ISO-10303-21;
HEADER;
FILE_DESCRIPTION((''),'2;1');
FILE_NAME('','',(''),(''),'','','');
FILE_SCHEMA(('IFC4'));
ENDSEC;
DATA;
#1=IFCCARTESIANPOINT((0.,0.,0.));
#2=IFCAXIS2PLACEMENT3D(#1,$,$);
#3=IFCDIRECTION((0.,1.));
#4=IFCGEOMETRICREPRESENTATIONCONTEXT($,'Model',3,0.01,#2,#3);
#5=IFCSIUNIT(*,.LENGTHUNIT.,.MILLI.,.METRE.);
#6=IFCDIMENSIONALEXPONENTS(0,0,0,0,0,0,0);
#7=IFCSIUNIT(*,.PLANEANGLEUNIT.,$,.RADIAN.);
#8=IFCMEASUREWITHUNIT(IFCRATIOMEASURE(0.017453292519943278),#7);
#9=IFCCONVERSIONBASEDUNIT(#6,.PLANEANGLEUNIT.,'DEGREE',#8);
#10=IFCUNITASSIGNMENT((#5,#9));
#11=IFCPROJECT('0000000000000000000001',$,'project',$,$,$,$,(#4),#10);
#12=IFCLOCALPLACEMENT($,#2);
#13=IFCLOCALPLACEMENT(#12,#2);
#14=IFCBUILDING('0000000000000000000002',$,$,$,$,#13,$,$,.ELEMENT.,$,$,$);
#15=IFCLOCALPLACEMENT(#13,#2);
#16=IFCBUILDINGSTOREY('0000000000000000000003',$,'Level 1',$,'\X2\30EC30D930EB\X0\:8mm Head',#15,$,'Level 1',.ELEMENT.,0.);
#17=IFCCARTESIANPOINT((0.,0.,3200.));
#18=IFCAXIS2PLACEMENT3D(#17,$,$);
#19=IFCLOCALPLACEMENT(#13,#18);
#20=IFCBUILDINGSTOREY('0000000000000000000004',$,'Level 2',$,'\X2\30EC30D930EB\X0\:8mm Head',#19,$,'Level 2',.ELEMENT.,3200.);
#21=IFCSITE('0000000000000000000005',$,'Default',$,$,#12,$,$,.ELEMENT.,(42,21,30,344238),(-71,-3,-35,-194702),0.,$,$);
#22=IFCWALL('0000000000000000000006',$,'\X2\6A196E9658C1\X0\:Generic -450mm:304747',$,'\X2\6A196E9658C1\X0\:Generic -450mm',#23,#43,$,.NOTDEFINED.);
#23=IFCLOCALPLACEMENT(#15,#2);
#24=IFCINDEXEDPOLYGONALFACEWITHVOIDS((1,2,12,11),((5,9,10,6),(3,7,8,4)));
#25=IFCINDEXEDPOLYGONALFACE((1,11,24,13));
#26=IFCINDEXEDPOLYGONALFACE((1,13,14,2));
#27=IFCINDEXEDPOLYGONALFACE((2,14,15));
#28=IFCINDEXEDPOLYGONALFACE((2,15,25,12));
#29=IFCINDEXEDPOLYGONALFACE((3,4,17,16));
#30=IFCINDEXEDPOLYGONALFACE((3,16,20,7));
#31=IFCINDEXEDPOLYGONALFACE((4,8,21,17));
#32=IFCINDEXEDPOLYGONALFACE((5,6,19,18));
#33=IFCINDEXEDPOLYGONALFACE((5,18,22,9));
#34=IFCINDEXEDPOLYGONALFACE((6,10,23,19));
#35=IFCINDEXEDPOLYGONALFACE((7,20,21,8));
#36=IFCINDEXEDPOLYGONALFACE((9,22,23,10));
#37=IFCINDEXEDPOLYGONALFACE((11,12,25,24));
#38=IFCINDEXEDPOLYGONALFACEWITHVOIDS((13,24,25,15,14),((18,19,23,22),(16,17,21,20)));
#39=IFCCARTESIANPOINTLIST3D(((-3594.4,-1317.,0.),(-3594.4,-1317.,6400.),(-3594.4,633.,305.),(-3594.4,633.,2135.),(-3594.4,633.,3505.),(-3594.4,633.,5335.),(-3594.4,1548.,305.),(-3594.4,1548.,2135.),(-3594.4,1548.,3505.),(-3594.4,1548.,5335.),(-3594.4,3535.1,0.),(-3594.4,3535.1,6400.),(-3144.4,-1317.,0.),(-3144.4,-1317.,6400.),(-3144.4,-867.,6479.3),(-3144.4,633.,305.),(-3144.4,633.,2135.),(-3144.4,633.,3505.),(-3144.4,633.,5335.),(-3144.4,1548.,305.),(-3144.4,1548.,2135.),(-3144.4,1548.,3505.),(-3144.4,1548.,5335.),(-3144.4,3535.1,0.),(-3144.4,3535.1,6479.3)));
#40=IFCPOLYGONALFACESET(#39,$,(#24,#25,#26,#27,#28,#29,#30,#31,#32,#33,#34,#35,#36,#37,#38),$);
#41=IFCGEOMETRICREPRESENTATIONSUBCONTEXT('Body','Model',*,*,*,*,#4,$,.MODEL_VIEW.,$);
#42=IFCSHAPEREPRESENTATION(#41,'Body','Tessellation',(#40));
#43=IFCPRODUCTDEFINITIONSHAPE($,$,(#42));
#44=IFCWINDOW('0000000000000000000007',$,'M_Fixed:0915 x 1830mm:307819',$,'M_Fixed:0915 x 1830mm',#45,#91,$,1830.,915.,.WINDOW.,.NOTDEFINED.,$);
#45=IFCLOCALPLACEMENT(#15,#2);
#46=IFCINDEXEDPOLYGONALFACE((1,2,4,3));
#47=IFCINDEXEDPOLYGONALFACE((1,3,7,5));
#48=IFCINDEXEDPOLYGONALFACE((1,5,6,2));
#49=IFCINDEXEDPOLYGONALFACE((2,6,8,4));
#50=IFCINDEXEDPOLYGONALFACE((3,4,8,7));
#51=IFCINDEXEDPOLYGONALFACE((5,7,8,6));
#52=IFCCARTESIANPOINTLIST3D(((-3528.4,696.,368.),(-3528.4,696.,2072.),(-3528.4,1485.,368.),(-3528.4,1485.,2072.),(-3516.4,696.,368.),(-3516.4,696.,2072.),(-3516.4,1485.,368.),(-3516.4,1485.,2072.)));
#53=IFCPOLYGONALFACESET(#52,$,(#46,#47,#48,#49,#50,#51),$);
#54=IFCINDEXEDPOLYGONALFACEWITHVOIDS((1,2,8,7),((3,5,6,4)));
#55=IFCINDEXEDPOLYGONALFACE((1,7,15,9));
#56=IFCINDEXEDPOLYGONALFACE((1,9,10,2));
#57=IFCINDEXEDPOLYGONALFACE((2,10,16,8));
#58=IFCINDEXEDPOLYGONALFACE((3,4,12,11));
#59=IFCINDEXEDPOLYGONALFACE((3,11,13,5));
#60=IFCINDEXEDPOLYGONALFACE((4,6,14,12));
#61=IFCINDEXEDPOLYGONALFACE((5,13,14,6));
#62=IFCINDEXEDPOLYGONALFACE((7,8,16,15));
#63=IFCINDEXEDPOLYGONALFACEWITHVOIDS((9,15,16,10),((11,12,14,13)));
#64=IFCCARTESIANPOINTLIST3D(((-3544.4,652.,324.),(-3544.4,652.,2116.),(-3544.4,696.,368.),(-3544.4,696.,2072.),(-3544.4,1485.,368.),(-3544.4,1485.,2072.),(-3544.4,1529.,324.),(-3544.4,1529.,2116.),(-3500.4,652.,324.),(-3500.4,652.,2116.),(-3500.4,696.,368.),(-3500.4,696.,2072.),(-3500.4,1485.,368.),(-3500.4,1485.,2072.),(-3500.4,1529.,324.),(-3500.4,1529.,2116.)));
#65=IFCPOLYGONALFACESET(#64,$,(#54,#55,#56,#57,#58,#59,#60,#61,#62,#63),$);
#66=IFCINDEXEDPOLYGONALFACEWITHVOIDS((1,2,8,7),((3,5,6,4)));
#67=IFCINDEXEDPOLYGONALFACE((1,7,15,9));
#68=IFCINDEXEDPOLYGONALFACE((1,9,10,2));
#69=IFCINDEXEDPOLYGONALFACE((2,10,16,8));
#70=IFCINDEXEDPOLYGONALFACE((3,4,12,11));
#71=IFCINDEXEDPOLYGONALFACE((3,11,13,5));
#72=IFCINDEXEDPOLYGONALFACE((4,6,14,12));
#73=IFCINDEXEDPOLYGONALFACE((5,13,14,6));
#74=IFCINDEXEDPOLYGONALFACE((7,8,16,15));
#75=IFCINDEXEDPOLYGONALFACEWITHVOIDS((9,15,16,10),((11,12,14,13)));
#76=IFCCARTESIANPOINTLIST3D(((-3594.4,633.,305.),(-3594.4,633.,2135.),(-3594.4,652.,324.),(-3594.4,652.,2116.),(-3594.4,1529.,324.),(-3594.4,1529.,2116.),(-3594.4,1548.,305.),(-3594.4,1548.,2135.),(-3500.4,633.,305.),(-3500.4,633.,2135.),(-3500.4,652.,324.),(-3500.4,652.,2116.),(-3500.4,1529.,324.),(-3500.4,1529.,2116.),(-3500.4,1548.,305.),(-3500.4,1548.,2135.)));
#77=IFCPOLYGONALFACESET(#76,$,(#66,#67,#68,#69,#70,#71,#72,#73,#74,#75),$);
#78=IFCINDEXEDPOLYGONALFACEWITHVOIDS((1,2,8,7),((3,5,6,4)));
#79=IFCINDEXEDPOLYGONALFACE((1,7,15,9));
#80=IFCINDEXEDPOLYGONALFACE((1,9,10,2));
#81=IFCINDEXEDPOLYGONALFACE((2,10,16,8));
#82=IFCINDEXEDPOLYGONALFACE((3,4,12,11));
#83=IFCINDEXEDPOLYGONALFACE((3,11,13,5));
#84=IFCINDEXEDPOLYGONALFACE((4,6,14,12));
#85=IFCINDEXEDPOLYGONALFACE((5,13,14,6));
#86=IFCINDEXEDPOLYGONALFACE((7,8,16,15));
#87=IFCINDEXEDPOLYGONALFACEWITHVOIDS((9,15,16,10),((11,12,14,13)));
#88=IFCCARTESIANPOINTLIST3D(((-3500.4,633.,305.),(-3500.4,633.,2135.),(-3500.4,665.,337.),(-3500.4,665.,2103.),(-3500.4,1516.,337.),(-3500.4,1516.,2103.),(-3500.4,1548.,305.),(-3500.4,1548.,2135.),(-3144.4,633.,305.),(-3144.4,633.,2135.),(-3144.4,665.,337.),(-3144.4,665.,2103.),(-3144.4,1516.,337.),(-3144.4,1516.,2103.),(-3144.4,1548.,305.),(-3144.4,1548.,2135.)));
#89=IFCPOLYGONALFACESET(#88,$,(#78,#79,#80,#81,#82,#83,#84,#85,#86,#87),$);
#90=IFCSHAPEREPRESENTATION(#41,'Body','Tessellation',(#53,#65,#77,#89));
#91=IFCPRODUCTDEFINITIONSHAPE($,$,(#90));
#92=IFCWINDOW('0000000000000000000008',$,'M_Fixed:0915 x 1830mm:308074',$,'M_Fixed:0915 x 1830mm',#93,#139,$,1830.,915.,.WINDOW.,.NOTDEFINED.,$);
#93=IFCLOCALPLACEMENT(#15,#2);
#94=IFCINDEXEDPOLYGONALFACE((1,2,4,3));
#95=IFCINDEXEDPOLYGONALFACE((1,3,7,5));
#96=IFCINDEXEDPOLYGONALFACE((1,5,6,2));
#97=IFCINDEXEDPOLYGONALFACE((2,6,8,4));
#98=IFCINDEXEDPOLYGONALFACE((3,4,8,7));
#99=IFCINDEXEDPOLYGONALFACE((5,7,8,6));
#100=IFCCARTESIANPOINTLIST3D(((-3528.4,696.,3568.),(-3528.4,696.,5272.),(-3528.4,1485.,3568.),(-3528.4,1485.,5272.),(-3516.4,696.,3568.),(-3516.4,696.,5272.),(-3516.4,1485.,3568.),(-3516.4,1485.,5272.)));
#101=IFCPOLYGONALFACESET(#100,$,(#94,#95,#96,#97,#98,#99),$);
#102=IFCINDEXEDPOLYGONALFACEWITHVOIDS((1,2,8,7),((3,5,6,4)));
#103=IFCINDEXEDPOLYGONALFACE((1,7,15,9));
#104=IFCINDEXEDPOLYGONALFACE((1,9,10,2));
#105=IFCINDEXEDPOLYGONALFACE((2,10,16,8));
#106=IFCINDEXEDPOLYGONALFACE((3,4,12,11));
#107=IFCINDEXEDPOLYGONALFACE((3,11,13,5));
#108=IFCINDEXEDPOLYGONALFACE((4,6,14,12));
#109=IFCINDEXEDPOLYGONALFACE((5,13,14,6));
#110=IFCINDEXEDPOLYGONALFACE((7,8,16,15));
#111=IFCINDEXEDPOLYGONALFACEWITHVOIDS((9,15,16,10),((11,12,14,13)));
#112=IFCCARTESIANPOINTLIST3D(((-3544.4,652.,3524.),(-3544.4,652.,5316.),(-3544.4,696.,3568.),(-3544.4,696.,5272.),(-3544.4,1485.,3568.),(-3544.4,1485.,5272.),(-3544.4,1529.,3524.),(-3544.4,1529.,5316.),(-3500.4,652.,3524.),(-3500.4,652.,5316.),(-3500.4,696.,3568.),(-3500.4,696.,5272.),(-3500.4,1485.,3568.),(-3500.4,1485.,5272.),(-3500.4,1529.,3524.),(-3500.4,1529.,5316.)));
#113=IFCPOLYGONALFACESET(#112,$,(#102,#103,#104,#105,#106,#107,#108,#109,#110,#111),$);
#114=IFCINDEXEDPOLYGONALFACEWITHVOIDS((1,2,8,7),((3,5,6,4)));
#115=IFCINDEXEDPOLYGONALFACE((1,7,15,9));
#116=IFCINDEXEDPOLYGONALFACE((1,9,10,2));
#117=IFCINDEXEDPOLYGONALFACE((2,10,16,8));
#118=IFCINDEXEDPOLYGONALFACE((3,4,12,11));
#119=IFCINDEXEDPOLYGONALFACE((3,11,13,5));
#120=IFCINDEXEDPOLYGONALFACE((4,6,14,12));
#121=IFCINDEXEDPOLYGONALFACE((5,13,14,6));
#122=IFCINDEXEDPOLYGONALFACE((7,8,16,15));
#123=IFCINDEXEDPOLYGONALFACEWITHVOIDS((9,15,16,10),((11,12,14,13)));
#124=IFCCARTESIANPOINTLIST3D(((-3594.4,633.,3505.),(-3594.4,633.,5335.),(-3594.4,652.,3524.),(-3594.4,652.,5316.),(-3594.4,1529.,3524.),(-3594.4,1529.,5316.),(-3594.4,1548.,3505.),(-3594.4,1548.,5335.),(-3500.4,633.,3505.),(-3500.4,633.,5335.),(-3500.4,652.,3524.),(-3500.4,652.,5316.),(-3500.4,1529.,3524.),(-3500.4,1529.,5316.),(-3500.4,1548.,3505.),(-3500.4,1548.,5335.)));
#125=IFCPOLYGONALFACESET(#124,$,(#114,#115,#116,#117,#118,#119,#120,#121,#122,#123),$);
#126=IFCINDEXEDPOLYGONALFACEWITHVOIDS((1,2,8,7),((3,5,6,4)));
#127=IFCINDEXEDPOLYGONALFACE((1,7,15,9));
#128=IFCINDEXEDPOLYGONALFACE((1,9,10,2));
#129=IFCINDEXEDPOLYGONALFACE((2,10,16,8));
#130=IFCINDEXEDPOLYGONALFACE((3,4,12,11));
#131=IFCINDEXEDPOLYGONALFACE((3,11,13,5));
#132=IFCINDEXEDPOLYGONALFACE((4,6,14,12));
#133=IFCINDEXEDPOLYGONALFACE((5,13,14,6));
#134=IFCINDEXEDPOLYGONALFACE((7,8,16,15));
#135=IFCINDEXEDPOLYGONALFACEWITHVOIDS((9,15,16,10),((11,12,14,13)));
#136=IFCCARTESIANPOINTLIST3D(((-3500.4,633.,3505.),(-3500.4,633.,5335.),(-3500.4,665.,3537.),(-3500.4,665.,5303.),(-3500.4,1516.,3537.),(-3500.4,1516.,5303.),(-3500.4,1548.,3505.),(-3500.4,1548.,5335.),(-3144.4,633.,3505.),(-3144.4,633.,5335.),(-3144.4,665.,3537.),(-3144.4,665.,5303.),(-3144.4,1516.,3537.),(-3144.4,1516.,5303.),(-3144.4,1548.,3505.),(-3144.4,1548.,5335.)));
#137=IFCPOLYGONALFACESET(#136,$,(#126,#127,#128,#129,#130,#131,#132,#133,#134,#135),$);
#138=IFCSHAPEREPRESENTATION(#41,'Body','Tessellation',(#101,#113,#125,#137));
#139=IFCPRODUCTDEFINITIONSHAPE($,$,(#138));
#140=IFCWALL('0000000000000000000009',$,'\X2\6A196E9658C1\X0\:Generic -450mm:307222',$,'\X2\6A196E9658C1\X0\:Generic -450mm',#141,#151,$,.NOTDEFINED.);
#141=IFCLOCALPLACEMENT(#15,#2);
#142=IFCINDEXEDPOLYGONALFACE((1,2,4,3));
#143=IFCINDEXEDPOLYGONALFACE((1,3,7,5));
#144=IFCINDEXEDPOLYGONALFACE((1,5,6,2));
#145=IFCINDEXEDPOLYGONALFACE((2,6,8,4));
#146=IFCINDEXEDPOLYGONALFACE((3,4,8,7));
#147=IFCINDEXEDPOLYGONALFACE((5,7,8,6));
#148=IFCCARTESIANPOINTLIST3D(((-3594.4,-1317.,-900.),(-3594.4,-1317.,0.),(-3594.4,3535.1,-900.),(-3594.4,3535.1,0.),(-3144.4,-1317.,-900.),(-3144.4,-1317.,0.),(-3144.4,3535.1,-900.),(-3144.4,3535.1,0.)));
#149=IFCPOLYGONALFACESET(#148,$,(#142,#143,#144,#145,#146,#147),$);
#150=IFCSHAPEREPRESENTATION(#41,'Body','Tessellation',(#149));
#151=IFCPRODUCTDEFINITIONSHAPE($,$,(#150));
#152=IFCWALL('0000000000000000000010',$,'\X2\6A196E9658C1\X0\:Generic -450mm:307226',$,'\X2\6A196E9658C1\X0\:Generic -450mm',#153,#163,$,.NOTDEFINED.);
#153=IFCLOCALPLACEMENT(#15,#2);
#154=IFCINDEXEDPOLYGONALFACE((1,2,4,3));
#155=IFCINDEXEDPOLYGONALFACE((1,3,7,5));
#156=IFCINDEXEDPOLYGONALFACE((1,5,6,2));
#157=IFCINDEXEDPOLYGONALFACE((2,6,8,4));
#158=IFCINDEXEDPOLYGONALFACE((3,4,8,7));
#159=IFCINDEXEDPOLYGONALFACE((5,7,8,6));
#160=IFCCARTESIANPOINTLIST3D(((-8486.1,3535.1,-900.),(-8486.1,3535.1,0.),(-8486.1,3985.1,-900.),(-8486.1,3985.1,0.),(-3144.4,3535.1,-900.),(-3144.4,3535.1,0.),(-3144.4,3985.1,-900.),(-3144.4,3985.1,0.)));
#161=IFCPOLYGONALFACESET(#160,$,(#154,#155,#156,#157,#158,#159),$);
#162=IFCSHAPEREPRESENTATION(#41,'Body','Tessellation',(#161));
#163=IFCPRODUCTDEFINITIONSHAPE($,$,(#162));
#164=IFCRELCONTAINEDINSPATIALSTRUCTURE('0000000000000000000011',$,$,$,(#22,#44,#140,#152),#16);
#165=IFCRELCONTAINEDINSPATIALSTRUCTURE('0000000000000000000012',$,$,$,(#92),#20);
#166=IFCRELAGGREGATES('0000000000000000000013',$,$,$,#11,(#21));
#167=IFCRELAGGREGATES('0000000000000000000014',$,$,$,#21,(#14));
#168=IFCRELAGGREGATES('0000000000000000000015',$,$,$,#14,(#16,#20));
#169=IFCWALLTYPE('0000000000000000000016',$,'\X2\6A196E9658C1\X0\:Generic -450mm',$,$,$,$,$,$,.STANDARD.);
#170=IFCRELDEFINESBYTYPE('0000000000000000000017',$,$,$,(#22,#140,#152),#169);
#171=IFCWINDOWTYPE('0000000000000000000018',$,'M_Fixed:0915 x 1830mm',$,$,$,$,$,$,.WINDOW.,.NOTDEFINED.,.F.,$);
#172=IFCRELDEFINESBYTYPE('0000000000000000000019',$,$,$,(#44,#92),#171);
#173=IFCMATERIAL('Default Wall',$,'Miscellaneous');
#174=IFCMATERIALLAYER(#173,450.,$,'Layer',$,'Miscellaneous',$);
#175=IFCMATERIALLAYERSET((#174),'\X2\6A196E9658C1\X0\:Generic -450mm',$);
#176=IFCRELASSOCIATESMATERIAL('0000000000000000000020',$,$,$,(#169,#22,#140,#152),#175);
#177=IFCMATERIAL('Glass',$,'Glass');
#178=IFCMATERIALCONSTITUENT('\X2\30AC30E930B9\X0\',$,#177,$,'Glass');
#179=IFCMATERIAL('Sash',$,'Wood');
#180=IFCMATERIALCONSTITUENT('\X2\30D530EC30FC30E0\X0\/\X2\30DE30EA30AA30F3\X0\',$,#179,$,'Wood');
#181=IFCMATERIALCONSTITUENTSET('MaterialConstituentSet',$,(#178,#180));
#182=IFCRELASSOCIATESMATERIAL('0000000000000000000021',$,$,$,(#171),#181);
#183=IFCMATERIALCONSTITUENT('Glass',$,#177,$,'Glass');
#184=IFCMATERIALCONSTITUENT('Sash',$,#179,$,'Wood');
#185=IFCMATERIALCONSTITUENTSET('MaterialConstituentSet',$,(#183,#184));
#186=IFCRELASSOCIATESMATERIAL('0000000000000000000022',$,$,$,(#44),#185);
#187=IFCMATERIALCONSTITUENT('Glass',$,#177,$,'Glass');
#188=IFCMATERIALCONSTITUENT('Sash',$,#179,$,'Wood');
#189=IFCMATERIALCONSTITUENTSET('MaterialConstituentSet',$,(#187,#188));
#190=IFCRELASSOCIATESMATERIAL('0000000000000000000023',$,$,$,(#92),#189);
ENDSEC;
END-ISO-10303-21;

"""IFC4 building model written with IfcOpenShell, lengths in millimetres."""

from ifc_helpers import new_model, entity, si_unit, converted_unit, direction, frame, frame_2d, origin, origin_2d_with_axis, place, context, subcontext, project, spatial, polyline, rectangle, outline, extrude, clip, bounded_halfspace, source, transform, mapped, material, layer, layer_set, layer_usage, constituent, constituent_set, type_object, type_shapes, element, fill, save


model = new_model("IFC4")

# Units and contexts
model_context = context("Model", 3, precision=0.01, world=origin(), true_north=direction((0.0, 1.0)))
body_context = subcontext(model_context, "Body", "Model", "MODEL_VIEW")
ifc_project = project(units=[si_unit("LENGTHUNIT", "METRE", prefix="MILLI"), converted_unit("PLANEANGLEUNIT", "DEGREE", entity("IfcRatioMeasure", 0.017453292519943278), si_unit("PLANEANGLEUNIT", "RADIAN"), dimensions=[0, 0, 0, 0, 0, 0, 0])], contexts=[model_context])

# Site, building, storey
site_placement = place(None, origin())
site = spatial("IfcSite", under=ifc_project, at=site_placement, Name="Default", CompositionType="ELEMENT", RefLatitude=(42, 21, 30, 344238), RefLongitude=(-71, -3, -35, -194702), RefElevation=0.0)
building_placement = place(site_placement, origin())
building = spatial("IfcBuilding", under=site, at=building_placement, CompositionType="ELEMENT")
storey_1_placement = place(building_placement, origin())
storey_1 = spatial("IfcBuildingStorey", under=building, at=storey_1_placement, Name="Level 1", ObjectType="レベル:8mm Head", LongName="Level 1", CompositionType="ELEMENT", Elevation=0.0)

# Wall, openings, window
ifc_material_1 = material(Name="Default Wall", Category="Miscellaneous")
ifc_layer_1 = layer(ifc_material_1, 450.0, Name="Layer", Category="Miscellaneous")
ifc_layer_set_1 = layer_set([ifc_layer_1], Name="標準壁:Generic -450mm")
ifc_layer_usage_1 = layer_usage(ifc_layer_set_1, "AXIS2", "NEGATIVE", 225.0)
wall_type_1 = type_object("IfcWallType", Name="標準壁:Generic -450mm", PredefinedType="STANDARD", material=ifc_layer_set_1)
wall_1_placement = place(storey_1_placement, frame((-3369.4, -1317.0, 0.0), z_axis=(0.0, 0.0, 1.0), x_axis=(0.0, 1.0, 0.0)))
wall_1 = element("IfcWall", 1, at=wall_1_placement, inside=storey_1, type_object=wall_type_1, material=ifc_layer_usage_1, Name="標準壁:Generic -450mm:304747", ObjectType="標準壁:Generic -450mm", PredefinedType="NOTDEFINED", context=body_context, shape_type="Clipping", body=[
    clip(clip(extrude(rectangle(XDim=4852.1, YDim=450.0, at=frame_2d((2426.0, 0.0), x_axis=(-1.0, 0.0))), origin(), (0.0, 0.0, 1.0), 6479.3), bounded_halfspace(frame((0.0, -225.0, 6400.0), z_axis=(-0.173648, 0.0, 0.984808), x_axis=(0.0, -1.0, 0.0)), False, frame((0.0, -225.0, 6400.0)), polyline([(0.0, 0.0), (450.0, 0.0), (0.0, 450.0), (0.0, 0.0)]))), bounded_halfspace(frame((450.0, -225.0, 6479.3), z_axis=(0.0, 0.173648, 0.984808), x_axis=(-1.0, 0.0, 0.0)), False, frame((450.0, -225.0, 6479.3)), polyline([(0.0, 0.0), (4402.1, 0.0), (4402.1, 450.0), (-450.0, 450.0), (0.0, 0.0)]))),
])
opening_1_placement = place(wall_1_placement, frame((1950.0, -225.0, 305.0)))
opening_1 = element("IfcOpeningElement", 2, at=opening_1_placement, cuts=wall_1, PredefinedType="OPENING", context=body_context, shape_type="SweptSolid", body=[
    extrude(rectangle(XDim=1830.0, YDim=915.0, at=frame_2d((915.0, 457.5), x_axis=(1.0, 0.0))), frame((0.0, 0.0, 0.0), z_axis=(0.0, 1.0, 0.0), x_axis=(0.0, 0.0, 1.0)), (0.0, 0.0, 1.0), 450.0),
])
opening_2_placement = place(wall_1_placement, frame((1950.0, -225.0, 3505.0)))
opening_2 = element("IfcOpeningElement", 3, at=opening_2_placement, cuts=wall_1, PredefinedType="OPENING", context=body_context, shape_type="SweptSolid", body=[
    extrude(rectangle(XDim=1830.0, YDim=915.0, at=frame_2d((915.0, 457.5), x_axis=(1.0, 0.0))), frame((0.0, 0.0, 0.0), z_axis=(0.0, 1.0, 0.0), x_axis=(0.0, 0.0, 1.0)), (0.0, 0.0, 1.0), 450.0),
])
ifc_material_2 = material(Name="Glass", Category="Glass")
ifc_constituent_1 = constituent(ifc_material_2, Name="Glass", Category="Glass")
ifc_material_3 = material(Name="Sash", Category="Wood")
ifc_constituent_2 = constituent(ifc_material_3, Name="Sash", Category="Wood")
ifc_constituent_set_1 = constituent_set(constituents=[ifc_constituent_1, ifc_constituent_2], Name="MaterialConstituentSet")
ifc_constituent_3 = constituent(ifc_material_2, Name="ガラス", Category="Glass")
ifc_constituent_4 = constituent(ifc_material_3, Name="フレーム/マリオン", Category="Wood")
ifc_constituent_set_2 = constituent_set(constituents=[ifc_constituent_3, ifc_constituent_4], Name="MaterialConstituentSet")
window_type = type_object("IfcWindowType", Name="M_Fixed:0915 x 1830mm", ParameterTakesPrecedence=False, PartitioningType="NOTDEFINED", PredefinedType="WINDOW", material=ifc_constituent_set_2)
shared_shape_1 = source(origin(), body_context, "Body", "SweptSolid", [
    extrude(rectangle(XDim=12.0, YDim=789.0, at=origin_2d_with_axis()), frame((457.5, 378.0, 63.0), z_axis=(0.0, 0.0, 1.0), x_axis=(0.0, -1.0, 0.0)), (0.0, 0.0, 1.0), 1704.0),
    extrude(outline(polyline([(-438.5, -896.0), (438.5, -896.0), (438.5, 896.0), (-438.5, 896.0), (-438.5, -896.0)]), holes=[polyline([(-394.5, -852.0), (-394.5, 852.0), (394.5, 852.0), (394.5, -852.0), (-394.5, -852.0)])]), frame((457.5, 356.0, 915.0), z_axis=(0.0, 1.0, 0.0), x_axis=(1.0, 0.0, 0.0)), (0.0, 0.0, 1.0), 44.0),
    extrude(outline(polyline([(-457.5, -915.0), (457.5, -915.0), (457.5, 915.0), (-457.5, 915.0), (-457.5, -915.0)]), holes=[polyline([(-438.5, -896.0), (-438.5, 896.0), (438.5, 896.0), (438.5, -896.0), (-438.5, -896.0)])]), frame((457.5, 356.0, 915.0), z_axis=(0.0, 1.0, 0.0), x_axis=(1.0, 0.0, 0.0)), (0.0, 0.0, 1.0), 94.0),
    extrude(outline(polyline([(-457.5, -915.0), (457.5, -915.0), (457.5, 915.0), (-457.5, 915.0), (-457.5, -915.0)]), holes=[polyline([(-425.5, -883.0), (-425.5, 883.0), (425.5, 883.0), (425.5, -883.0), (-425.5, -883.0)])]), frame((457.5, 0.0, 915.0), z_axis=(0.0, 1.0, 0.0), x_axis=(1.0, 0.0, 0.0)), (0.0, 0.0, 1.0), 356.0),
])
type_shapes(window_type, [shared_shape_1])
window_1_placement = place(opening_1_placement, origin())
window_1 = element("IfcWindow", 4, at=window_1_placement, inside=storey_1, type_object=window_type, material=ifc_constituent_set_1, Name="M_Fixed:0915 x 1830mm:307819", ObjectType="M_Fixed:0915 x 1830mm", OverallHeight=1830.0, OverallWidth=915.0, PartitioningType="NOTDEFINED", PredefinedType="WINDOW", context=body_context, shape_type="MappedRepresentation", body=[
    mapped(shared_shape_1, transform((0.0, 0.0, 0.0), scale=1.0)),
])
fill(opening_1, window_1)

# Shared definitions
storey_2_placement = place(building_placement, frame((0.0, 0.0, 3200.0)))
storey_2 = spatial("IfcBuildingStorey", under=building, at=storey_2_placement, Name="Level 2", ObjectType="レベル:8mm Head", LongName="Level 2", CompositionType="ELEMENT", Elevation=3200.0)

# Window
ifc_constituent_5 = constituent(ifc_material_2, Name="Glass", Category="Glass")
ifc_constituent_6 = constituent(ifc_material_3, Name="Sash", Category="Wood")
ifc_constituent_set_3 = constituent_set(constituents=[ifc_constituent_5, ifc_constituent_6], Name="MaterialConstituentSet")
window_2_placement = place(opening_2_placement, origin())
window_2 = element("IfcWindow", 5, at=window_2_placement, inside=storey_2, type_object=window_type, material=ifc_constituent_set_3, Name="M_Fixed:0915 x 1830mm:308074", ObjectType="M_Fixed:0915 x 1830mm", OverallHeight=1830.0, OverallWidth=915.0, PartitioningType="NOTDEFINED", PredefinedType="WINDOW", context=body_context, shape_type="MappedRepresentation", body=[
    mapped(shared_shape_1, transform((0.0, 0.0, 0.0), scale=1.0)),
])
fill(opening_2, window_2)

# Walls
ifc_layer_usage_2 = layer_usage(ifc_layer_set_1, "AXIS2", "NEGATIVE", 225.0)
wall_2_placement = place(storey_1_placement, frame((-3369.4, -1317.0, -900.0), z_axis=(0.0, 0.0, 1.0), x_axis=(0.0, 1.0, 0.0)))
element("IfcWall", 6, at=wall_2_placement, inside=storey_1, type_object=wall_type_1, material=ifc_layer_usage_2, Name="標準壁:Generic -450mm:307222", ObjectType="標準壁:Generic -450mm", PredefinedType="NOTDEFINED", context=body_context, shape_type="SweptSolid", body=[
    extrude(rectangle(XDim=4852.1, YDim=450.0, at=frame_2d((2426.0, 0.0), x_axis=(-1.0, 0.0))), origin(), (0.0, 0.0, 1.0), 900.0),
])
ifc_layer_usage_3 = layer_usage(ifc_layer_set_1, "AXIS2", "NEGATIVE", 225.0)
wall_3_placement = place(storey_1_placement, frame((-3144.4, 3760.1, -900.0), z_axis=(0.0, 0.0, 1.0), x_axis=(-1.0, 0.0, 0.0)))
element("IfcWall", 7, at=wall_3_placement, inside=storey_1, type_object=wall_type_1, material=ifc_layer_usage_3, Name="標準壁:Generic -450mm:307226", ObjectType="標準壁:Generic -450mm", PredefinedType="NOTDEFINED", context=body_context, shape_type="SweptSolid", body=[
    extrude(rectangle(XDim=5341.7, YDim=450.0, at=frame_2d((2670.8, 0.0), x_axis=(-1.0, 0.0))), origin(), (0.0, 0.0, 1.0), 900.0),
])

save(model, "model.ifc")
